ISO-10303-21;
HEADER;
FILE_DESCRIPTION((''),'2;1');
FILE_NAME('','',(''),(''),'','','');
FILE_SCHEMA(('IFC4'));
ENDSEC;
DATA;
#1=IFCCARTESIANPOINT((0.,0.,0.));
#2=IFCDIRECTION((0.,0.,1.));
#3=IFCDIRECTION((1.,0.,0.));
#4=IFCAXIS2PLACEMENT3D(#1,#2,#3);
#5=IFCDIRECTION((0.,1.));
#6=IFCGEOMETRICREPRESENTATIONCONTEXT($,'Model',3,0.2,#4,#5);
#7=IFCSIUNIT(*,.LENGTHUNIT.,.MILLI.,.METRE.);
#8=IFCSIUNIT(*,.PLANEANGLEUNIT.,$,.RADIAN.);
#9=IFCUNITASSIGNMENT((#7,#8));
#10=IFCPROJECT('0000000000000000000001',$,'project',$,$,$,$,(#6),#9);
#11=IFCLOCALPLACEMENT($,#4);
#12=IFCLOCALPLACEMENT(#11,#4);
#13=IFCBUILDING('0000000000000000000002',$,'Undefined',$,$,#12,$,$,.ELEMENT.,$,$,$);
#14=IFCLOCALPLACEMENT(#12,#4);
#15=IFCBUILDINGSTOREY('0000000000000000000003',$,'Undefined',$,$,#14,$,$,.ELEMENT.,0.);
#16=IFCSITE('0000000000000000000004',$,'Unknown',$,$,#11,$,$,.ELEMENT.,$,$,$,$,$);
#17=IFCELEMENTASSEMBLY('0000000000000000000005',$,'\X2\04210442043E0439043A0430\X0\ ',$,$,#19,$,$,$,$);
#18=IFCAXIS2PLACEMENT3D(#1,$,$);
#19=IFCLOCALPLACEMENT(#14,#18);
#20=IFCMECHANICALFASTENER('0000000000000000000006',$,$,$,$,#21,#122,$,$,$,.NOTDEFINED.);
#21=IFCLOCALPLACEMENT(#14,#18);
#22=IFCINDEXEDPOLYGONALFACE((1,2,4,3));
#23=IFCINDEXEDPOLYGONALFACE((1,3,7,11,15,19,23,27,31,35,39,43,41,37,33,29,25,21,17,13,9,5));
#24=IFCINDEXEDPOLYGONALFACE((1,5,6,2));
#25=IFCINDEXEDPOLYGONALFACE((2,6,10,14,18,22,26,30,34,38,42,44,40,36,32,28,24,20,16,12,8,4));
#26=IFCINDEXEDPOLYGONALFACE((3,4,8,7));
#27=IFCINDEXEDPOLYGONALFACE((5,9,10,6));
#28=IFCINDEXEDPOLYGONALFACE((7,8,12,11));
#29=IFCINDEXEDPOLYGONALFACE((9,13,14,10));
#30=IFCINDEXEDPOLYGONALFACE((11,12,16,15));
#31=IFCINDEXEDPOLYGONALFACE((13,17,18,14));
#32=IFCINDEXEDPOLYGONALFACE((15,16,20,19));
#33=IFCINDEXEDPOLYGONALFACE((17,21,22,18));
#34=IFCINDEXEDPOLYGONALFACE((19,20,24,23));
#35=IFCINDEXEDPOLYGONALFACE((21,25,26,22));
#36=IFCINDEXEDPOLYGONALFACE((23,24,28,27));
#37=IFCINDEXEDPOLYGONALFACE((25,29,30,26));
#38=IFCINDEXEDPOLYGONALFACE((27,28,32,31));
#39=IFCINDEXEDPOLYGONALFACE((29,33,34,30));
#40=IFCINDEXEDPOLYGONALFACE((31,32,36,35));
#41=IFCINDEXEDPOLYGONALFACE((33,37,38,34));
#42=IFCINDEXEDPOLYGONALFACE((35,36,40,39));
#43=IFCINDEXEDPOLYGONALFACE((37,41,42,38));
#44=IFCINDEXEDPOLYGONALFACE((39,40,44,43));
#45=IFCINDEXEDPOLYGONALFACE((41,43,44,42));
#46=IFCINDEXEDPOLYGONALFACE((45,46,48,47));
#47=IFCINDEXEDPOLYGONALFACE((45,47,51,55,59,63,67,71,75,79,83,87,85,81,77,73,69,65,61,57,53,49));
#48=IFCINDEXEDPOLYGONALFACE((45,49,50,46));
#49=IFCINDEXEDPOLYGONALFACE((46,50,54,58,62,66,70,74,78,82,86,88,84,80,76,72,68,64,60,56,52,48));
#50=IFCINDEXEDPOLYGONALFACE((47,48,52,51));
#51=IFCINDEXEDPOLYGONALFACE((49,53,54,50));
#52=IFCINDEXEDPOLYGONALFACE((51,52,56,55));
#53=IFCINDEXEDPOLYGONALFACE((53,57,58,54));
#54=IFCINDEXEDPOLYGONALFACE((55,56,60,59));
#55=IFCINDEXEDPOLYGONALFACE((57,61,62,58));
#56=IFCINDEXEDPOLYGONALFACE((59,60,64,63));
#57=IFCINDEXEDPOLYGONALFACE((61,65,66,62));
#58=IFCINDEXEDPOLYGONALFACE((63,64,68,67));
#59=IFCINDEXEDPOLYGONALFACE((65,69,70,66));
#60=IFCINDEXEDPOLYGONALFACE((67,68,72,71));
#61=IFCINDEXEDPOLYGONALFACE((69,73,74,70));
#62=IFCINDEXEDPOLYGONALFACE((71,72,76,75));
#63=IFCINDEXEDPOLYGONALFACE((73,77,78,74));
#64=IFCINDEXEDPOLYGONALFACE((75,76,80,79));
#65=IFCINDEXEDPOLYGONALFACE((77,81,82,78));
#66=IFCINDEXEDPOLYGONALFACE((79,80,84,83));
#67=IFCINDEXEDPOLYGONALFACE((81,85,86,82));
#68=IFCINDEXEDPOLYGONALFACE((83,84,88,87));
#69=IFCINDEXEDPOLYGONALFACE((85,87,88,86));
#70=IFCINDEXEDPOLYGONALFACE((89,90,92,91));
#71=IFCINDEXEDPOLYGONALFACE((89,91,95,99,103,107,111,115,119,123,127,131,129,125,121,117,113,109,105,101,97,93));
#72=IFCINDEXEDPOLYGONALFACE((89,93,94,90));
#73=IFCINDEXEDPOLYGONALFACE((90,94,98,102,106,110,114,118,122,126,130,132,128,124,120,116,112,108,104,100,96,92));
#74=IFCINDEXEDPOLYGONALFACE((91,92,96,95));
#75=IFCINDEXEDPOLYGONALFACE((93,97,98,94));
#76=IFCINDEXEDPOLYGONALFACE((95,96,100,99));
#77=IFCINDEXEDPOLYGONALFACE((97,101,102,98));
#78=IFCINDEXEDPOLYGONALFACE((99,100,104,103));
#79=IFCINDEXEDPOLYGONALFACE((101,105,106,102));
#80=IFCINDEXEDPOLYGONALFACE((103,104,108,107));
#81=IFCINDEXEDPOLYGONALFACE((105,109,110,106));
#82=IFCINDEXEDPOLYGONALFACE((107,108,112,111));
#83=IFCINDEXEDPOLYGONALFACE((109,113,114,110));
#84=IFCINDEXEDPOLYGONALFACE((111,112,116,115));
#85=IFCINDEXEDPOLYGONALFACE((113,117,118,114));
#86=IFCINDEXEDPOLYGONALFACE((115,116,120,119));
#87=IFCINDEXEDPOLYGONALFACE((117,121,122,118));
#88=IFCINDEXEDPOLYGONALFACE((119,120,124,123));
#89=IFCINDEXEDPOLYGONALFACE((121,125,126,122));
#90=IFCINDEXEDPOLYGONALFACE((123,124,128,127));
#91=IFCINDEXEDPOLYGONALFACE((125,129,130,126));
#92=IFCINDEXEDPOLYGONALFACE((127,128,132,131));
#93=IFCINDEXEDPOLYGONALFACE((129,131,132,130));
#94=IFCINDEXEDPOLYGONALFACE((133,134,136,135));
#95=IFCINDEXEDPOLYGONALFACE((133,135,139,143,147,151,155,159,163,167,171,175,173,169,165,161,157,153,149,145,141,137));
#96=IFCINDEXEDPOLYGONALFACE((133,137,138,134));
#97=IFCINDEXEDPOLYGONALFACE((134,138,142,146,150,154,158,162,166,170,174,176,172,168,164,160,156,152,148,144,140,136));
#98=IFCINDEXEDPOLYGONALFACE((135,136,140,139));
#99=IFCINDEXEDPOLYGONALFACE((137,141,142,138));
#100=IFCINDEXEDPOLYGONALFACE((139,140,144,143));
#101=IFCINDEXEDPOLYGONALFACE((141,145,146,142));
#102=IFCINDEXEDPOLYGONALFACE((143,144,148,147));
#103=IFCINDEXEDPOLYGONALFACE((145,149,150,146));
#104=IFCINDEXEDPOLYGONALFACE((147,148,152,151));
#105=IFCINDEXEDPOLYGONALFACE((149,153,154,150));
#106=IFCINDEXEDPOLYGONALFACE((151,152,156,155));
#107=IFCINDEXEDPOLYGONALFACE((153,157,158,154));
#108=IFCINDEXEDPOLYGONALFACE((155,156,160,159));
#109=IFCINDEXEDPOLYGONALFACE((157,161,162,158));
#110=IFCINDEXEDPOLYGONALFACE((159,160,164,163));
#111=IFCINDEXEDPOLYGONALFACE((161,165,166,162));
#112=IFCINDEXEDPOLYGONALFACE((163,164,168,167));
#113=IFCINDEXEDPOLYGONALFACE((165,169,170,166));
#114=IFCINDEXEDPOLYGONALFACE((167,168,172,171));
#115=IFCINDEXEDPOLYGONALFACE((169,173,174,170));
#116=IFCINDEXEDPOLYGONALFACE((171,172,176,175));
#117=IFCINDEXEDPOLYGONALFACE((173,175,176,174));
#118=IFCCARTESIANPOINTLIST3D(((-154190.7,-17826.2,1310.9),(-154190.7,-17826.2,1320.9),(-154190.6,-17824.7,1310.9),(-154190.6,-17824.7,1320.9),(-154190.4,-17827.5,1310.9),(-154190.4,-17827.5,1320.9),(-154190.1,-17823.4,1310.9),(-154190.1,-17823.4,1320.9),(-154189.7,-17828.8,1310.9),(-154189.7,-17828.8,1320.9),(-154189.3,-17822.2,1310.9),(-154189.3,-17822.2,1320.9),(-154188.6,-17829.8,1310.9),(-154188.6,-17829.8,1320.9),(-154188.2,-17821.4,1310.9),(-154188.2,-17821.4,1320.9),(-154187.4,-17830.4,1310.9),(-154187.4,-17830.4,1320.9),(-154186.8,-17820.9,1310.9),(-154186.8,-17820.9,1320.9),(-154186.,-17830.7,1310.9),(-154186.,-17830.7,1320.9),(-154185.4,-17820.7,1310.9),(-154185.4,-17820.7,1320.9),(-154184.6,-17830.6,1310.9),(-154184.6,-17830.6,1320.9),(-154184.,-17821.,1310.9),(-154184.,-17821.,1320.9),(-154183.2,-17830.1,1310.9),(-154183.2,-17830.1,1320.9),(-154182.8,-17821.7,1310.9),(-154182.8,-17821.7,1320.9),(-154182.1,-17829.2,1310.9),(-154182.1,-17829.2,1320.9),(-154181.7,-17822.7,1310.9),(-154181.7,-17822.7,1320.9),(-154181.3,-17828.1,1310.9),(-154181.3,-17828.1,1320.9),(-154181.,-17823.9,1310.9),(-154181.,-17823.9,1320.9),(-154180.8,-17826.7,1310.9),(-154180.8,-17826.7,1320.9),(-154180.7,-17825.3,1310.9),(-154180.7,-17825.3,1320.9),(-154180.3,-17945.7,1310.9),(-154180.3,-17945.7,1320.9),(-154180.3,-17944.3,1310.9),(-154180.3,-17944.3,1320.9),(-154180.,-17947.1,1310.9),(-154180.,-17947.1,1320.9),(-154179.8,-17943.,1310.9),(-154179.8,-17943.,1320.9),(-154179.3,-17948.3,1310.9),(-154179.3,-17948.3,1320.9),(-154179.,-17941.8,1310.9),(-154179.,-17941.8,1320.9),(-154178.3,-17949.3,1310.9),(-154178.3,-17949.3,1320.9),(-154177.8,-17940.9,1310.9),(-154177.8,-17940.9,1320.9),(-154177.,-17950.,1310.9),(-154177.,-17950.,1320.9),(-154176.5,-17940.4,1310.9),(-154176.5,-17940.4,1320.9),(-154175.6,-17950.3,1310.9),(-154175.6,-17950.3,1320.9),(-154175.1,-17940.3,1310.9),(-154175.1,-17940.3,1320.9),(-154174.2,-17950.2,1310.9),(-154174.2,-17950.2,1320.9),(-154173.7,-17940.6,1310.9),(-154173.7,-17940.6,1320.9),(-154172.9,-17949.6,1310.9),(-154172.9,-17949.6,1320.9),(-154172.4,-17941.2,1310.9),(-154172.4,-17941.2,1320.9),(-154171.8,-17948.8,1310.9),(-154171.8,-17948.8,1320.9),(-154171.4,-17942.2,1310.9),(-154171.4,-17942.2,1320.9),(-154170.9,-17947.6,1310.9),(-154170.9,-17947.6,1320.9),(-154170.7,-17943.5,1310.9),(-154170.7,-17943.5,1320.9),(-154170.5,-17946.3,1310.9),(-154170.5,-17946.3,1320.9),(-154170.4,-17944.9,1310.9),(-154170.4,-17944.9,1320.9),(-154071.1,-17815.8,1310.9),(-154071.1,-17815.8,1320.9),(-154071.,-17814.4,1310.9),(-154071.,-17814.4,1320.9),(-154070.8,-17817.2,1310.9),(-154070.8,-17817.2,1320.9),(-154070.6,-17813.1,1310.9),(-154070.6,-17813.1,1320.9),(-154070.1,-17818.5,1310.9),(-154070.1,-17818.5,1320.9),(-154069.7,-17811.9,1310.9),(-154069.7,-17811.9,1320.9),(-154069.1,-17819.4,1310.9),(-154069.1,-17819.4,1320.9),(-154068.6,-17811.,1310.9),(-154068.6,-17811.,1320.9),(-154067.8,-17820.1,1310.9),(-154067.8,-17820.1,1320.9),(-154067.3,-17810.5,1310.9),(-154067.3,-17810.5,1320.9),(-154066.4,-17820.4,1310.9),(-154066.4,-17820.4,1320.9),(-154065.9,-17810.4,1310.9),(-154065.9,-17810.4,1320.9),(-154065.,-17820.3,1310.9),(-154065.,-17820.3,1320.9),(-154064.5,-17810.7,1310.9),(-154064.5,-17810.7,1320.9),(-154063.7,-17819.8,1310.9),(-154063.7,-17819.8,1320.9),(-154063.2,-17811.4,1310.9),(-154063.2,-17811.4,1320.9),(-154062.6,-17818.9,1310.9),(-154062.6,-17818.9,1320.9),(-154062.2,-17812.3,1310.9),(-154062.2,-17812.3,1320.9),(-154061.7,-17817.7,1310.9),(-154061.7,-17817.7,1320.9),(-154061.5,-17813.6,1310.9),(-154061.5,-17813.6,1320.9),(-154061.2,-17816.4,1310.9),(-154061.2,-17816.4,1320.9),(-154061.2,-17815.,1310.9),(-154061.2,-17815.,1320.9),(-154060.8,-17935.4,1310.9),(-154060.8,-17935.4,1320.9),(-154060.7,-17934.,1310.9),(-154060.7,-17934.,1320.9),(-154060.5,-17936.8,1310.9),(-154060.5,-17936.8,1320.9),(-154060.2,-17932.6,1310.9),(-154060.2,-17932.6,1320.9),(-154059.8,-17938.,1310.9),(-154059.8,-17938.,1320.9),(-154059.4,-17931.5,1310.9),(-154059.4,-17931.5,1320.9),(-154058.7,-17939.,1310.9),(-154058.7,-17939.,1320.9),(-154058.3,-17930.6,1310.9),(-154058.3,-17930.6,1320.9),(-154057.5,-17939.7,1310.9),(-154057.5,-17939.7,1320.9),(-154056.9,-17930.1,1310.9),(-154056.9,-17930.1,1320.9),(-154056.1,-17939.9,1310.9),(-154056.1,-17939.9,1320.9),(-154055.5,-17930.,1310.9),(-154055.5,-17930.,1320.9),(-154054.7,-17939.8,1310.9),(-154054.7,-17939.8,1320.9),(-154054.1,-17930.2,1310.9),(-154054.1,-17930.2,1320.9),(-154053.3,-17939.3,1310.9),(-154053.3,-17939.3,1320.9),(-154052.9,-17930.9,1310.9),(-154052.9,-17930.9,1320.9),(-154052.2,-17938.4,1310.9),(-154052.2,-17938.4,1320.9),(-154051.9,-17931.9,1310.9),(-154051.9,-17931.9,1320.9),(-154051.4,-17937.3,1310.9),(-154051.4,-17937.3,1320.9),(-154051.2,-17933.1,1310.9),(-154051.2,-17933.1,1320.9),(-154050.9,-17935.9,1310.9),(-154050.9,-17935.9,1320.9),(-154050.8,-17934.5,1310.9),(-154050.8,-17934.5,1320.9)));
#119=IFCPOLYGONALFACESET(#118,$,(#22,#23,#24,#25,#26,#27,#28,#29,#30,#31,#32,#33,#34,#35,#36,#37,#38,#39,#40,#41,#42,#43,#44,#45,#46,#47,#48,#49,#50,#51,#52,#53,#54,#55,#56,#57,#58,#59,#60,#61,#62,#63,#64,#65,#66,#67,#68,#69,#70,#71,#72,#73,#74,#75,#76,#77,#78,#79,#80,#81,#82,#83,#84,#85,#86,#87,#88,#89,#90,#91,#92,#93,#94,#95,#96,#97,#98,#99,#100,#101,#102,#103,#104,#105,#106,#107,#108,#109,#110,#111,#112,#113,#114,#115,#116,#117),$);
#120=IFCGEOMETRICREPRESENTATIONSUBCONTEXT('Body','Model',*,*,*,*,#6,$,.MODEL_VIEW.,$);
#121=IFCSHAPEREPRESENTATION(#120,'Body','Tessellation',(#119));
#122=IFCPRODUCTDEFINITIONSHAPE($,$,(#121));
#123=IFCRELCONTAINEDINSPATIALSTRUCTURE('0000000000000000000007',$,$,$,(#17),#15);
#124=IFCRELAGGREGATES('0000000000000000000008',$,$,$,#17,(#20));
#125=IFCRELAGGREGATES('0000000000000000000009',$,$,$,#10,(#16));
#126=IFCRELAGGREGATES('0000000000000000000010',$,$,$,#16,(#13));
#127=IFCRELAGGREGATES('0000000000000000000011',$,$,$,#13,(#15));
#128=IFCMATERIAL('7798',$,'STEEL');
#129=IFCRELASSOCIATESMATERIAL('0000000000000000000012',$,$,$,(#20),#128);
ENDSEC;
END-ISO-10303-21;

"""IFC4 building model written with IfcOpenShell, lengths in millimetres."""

from ifc_helpers import new_model, si_unit, direction, frame, origin_with_axes, place, context, subcontext, project, spatial, arc, indexed_curve, outline, extrude, source, transform, mapped, material, element, aggregate, save


model = new_model("IFC4")

# Units and contexts
model_context = context("Model", 3, precision=0.2, world=origin_with_axes(), true_north=direction((0.0, 1.0)))
body_context = subcontext(model_context, "Body", "Model", "MODEL_VIEW")
ifc_project = project(units=[si_unit("LENGTHUNIT", "METRE", prefix="MILLI"), si_unit("PLANEANGLEUNIT", "RADIAN")], contexts=[model_context])

# Site, building, storey
site_placement = place(None, origin_with_axes())
site = spatial("IfcSite", under=ifc_project, at=site_placement, Name="Unknown", CompositionType="ELEMENT")
building_placement = place(site_placement, origin_with_axes())
building = spatial("IfcBuilding", under=site, at=building_placement, Name="Undefined", CompositionType="ELEMENT")
storey_placement = place(building_placement, origin_with_axes())
storey = spatial("IfcBuildingStorey", under=building, at=storey_placement, Name="Undefined", CompositionType="ELEMENT", Elevation=0.0)

# Element assembly
assembly_1_placement = place(storey_placement, frame((-154120.8, -17880.2, 4823.9), z_axis=(0.086114, -0.996285, 0.0), x_axis=(0.0, 0.0, -1.0)))
assembly_1 = element("IfcElementAssembly", 1, at=assembly_1_placement, inside=storey, Name="Стойка ")

# Mechanical fastener
ifc_material_1 = material(Name="7798", Category="STEEL")
shared_shape_1 = source(origin_with_axes(), body_context, "Body", "SweptSolid", [
    extrude(outline(indexed_curve([(5.0, 0.0), (0.0, 5.0), (-5.0, 0.0), (0.0, -5.0)], segments=[arc(1, 2, 3), arc(3, 4, 1)])), frame((0.0, 0.0, 10.0), z_axis=(0.0, 0.0, -1.0), x_axis=(0.0, 1.0, 0.0)), (0.0, 0.0, 1.0), 10.0),
])
mechanical_fastener_1_placement = place(assembly_1_placement, frame((3513.0, 0.0, -59.9), z_axis=(-1.0, 0.0, 0.0), x_axis=(0.0, 0.0, 1.0)))
mechanical_fastener_1 = element("IfcMechanicalFastener", 2, at=mechanical_fastener_1_placement, material=ifc_material_1, PredefinedType="NOTDEFINED", context=body_context, shape_type="MappedRepresentation", body=[
    mapped(shared_shape_1, transform((0.0, -60.0, 0.0))),
    mapped(shared_shape_1, transform((120.0, -60.0, 0.0))),
    mapped(shared_shape_1, transform((0.0, 60.0, 0.0))),
    mapped(shared_shape_1, transform((120.0, 60.0, 0.0))),
])
aggregate(assembly_1, [mechanical_fastener_1])

save(model, "model.ifc")
